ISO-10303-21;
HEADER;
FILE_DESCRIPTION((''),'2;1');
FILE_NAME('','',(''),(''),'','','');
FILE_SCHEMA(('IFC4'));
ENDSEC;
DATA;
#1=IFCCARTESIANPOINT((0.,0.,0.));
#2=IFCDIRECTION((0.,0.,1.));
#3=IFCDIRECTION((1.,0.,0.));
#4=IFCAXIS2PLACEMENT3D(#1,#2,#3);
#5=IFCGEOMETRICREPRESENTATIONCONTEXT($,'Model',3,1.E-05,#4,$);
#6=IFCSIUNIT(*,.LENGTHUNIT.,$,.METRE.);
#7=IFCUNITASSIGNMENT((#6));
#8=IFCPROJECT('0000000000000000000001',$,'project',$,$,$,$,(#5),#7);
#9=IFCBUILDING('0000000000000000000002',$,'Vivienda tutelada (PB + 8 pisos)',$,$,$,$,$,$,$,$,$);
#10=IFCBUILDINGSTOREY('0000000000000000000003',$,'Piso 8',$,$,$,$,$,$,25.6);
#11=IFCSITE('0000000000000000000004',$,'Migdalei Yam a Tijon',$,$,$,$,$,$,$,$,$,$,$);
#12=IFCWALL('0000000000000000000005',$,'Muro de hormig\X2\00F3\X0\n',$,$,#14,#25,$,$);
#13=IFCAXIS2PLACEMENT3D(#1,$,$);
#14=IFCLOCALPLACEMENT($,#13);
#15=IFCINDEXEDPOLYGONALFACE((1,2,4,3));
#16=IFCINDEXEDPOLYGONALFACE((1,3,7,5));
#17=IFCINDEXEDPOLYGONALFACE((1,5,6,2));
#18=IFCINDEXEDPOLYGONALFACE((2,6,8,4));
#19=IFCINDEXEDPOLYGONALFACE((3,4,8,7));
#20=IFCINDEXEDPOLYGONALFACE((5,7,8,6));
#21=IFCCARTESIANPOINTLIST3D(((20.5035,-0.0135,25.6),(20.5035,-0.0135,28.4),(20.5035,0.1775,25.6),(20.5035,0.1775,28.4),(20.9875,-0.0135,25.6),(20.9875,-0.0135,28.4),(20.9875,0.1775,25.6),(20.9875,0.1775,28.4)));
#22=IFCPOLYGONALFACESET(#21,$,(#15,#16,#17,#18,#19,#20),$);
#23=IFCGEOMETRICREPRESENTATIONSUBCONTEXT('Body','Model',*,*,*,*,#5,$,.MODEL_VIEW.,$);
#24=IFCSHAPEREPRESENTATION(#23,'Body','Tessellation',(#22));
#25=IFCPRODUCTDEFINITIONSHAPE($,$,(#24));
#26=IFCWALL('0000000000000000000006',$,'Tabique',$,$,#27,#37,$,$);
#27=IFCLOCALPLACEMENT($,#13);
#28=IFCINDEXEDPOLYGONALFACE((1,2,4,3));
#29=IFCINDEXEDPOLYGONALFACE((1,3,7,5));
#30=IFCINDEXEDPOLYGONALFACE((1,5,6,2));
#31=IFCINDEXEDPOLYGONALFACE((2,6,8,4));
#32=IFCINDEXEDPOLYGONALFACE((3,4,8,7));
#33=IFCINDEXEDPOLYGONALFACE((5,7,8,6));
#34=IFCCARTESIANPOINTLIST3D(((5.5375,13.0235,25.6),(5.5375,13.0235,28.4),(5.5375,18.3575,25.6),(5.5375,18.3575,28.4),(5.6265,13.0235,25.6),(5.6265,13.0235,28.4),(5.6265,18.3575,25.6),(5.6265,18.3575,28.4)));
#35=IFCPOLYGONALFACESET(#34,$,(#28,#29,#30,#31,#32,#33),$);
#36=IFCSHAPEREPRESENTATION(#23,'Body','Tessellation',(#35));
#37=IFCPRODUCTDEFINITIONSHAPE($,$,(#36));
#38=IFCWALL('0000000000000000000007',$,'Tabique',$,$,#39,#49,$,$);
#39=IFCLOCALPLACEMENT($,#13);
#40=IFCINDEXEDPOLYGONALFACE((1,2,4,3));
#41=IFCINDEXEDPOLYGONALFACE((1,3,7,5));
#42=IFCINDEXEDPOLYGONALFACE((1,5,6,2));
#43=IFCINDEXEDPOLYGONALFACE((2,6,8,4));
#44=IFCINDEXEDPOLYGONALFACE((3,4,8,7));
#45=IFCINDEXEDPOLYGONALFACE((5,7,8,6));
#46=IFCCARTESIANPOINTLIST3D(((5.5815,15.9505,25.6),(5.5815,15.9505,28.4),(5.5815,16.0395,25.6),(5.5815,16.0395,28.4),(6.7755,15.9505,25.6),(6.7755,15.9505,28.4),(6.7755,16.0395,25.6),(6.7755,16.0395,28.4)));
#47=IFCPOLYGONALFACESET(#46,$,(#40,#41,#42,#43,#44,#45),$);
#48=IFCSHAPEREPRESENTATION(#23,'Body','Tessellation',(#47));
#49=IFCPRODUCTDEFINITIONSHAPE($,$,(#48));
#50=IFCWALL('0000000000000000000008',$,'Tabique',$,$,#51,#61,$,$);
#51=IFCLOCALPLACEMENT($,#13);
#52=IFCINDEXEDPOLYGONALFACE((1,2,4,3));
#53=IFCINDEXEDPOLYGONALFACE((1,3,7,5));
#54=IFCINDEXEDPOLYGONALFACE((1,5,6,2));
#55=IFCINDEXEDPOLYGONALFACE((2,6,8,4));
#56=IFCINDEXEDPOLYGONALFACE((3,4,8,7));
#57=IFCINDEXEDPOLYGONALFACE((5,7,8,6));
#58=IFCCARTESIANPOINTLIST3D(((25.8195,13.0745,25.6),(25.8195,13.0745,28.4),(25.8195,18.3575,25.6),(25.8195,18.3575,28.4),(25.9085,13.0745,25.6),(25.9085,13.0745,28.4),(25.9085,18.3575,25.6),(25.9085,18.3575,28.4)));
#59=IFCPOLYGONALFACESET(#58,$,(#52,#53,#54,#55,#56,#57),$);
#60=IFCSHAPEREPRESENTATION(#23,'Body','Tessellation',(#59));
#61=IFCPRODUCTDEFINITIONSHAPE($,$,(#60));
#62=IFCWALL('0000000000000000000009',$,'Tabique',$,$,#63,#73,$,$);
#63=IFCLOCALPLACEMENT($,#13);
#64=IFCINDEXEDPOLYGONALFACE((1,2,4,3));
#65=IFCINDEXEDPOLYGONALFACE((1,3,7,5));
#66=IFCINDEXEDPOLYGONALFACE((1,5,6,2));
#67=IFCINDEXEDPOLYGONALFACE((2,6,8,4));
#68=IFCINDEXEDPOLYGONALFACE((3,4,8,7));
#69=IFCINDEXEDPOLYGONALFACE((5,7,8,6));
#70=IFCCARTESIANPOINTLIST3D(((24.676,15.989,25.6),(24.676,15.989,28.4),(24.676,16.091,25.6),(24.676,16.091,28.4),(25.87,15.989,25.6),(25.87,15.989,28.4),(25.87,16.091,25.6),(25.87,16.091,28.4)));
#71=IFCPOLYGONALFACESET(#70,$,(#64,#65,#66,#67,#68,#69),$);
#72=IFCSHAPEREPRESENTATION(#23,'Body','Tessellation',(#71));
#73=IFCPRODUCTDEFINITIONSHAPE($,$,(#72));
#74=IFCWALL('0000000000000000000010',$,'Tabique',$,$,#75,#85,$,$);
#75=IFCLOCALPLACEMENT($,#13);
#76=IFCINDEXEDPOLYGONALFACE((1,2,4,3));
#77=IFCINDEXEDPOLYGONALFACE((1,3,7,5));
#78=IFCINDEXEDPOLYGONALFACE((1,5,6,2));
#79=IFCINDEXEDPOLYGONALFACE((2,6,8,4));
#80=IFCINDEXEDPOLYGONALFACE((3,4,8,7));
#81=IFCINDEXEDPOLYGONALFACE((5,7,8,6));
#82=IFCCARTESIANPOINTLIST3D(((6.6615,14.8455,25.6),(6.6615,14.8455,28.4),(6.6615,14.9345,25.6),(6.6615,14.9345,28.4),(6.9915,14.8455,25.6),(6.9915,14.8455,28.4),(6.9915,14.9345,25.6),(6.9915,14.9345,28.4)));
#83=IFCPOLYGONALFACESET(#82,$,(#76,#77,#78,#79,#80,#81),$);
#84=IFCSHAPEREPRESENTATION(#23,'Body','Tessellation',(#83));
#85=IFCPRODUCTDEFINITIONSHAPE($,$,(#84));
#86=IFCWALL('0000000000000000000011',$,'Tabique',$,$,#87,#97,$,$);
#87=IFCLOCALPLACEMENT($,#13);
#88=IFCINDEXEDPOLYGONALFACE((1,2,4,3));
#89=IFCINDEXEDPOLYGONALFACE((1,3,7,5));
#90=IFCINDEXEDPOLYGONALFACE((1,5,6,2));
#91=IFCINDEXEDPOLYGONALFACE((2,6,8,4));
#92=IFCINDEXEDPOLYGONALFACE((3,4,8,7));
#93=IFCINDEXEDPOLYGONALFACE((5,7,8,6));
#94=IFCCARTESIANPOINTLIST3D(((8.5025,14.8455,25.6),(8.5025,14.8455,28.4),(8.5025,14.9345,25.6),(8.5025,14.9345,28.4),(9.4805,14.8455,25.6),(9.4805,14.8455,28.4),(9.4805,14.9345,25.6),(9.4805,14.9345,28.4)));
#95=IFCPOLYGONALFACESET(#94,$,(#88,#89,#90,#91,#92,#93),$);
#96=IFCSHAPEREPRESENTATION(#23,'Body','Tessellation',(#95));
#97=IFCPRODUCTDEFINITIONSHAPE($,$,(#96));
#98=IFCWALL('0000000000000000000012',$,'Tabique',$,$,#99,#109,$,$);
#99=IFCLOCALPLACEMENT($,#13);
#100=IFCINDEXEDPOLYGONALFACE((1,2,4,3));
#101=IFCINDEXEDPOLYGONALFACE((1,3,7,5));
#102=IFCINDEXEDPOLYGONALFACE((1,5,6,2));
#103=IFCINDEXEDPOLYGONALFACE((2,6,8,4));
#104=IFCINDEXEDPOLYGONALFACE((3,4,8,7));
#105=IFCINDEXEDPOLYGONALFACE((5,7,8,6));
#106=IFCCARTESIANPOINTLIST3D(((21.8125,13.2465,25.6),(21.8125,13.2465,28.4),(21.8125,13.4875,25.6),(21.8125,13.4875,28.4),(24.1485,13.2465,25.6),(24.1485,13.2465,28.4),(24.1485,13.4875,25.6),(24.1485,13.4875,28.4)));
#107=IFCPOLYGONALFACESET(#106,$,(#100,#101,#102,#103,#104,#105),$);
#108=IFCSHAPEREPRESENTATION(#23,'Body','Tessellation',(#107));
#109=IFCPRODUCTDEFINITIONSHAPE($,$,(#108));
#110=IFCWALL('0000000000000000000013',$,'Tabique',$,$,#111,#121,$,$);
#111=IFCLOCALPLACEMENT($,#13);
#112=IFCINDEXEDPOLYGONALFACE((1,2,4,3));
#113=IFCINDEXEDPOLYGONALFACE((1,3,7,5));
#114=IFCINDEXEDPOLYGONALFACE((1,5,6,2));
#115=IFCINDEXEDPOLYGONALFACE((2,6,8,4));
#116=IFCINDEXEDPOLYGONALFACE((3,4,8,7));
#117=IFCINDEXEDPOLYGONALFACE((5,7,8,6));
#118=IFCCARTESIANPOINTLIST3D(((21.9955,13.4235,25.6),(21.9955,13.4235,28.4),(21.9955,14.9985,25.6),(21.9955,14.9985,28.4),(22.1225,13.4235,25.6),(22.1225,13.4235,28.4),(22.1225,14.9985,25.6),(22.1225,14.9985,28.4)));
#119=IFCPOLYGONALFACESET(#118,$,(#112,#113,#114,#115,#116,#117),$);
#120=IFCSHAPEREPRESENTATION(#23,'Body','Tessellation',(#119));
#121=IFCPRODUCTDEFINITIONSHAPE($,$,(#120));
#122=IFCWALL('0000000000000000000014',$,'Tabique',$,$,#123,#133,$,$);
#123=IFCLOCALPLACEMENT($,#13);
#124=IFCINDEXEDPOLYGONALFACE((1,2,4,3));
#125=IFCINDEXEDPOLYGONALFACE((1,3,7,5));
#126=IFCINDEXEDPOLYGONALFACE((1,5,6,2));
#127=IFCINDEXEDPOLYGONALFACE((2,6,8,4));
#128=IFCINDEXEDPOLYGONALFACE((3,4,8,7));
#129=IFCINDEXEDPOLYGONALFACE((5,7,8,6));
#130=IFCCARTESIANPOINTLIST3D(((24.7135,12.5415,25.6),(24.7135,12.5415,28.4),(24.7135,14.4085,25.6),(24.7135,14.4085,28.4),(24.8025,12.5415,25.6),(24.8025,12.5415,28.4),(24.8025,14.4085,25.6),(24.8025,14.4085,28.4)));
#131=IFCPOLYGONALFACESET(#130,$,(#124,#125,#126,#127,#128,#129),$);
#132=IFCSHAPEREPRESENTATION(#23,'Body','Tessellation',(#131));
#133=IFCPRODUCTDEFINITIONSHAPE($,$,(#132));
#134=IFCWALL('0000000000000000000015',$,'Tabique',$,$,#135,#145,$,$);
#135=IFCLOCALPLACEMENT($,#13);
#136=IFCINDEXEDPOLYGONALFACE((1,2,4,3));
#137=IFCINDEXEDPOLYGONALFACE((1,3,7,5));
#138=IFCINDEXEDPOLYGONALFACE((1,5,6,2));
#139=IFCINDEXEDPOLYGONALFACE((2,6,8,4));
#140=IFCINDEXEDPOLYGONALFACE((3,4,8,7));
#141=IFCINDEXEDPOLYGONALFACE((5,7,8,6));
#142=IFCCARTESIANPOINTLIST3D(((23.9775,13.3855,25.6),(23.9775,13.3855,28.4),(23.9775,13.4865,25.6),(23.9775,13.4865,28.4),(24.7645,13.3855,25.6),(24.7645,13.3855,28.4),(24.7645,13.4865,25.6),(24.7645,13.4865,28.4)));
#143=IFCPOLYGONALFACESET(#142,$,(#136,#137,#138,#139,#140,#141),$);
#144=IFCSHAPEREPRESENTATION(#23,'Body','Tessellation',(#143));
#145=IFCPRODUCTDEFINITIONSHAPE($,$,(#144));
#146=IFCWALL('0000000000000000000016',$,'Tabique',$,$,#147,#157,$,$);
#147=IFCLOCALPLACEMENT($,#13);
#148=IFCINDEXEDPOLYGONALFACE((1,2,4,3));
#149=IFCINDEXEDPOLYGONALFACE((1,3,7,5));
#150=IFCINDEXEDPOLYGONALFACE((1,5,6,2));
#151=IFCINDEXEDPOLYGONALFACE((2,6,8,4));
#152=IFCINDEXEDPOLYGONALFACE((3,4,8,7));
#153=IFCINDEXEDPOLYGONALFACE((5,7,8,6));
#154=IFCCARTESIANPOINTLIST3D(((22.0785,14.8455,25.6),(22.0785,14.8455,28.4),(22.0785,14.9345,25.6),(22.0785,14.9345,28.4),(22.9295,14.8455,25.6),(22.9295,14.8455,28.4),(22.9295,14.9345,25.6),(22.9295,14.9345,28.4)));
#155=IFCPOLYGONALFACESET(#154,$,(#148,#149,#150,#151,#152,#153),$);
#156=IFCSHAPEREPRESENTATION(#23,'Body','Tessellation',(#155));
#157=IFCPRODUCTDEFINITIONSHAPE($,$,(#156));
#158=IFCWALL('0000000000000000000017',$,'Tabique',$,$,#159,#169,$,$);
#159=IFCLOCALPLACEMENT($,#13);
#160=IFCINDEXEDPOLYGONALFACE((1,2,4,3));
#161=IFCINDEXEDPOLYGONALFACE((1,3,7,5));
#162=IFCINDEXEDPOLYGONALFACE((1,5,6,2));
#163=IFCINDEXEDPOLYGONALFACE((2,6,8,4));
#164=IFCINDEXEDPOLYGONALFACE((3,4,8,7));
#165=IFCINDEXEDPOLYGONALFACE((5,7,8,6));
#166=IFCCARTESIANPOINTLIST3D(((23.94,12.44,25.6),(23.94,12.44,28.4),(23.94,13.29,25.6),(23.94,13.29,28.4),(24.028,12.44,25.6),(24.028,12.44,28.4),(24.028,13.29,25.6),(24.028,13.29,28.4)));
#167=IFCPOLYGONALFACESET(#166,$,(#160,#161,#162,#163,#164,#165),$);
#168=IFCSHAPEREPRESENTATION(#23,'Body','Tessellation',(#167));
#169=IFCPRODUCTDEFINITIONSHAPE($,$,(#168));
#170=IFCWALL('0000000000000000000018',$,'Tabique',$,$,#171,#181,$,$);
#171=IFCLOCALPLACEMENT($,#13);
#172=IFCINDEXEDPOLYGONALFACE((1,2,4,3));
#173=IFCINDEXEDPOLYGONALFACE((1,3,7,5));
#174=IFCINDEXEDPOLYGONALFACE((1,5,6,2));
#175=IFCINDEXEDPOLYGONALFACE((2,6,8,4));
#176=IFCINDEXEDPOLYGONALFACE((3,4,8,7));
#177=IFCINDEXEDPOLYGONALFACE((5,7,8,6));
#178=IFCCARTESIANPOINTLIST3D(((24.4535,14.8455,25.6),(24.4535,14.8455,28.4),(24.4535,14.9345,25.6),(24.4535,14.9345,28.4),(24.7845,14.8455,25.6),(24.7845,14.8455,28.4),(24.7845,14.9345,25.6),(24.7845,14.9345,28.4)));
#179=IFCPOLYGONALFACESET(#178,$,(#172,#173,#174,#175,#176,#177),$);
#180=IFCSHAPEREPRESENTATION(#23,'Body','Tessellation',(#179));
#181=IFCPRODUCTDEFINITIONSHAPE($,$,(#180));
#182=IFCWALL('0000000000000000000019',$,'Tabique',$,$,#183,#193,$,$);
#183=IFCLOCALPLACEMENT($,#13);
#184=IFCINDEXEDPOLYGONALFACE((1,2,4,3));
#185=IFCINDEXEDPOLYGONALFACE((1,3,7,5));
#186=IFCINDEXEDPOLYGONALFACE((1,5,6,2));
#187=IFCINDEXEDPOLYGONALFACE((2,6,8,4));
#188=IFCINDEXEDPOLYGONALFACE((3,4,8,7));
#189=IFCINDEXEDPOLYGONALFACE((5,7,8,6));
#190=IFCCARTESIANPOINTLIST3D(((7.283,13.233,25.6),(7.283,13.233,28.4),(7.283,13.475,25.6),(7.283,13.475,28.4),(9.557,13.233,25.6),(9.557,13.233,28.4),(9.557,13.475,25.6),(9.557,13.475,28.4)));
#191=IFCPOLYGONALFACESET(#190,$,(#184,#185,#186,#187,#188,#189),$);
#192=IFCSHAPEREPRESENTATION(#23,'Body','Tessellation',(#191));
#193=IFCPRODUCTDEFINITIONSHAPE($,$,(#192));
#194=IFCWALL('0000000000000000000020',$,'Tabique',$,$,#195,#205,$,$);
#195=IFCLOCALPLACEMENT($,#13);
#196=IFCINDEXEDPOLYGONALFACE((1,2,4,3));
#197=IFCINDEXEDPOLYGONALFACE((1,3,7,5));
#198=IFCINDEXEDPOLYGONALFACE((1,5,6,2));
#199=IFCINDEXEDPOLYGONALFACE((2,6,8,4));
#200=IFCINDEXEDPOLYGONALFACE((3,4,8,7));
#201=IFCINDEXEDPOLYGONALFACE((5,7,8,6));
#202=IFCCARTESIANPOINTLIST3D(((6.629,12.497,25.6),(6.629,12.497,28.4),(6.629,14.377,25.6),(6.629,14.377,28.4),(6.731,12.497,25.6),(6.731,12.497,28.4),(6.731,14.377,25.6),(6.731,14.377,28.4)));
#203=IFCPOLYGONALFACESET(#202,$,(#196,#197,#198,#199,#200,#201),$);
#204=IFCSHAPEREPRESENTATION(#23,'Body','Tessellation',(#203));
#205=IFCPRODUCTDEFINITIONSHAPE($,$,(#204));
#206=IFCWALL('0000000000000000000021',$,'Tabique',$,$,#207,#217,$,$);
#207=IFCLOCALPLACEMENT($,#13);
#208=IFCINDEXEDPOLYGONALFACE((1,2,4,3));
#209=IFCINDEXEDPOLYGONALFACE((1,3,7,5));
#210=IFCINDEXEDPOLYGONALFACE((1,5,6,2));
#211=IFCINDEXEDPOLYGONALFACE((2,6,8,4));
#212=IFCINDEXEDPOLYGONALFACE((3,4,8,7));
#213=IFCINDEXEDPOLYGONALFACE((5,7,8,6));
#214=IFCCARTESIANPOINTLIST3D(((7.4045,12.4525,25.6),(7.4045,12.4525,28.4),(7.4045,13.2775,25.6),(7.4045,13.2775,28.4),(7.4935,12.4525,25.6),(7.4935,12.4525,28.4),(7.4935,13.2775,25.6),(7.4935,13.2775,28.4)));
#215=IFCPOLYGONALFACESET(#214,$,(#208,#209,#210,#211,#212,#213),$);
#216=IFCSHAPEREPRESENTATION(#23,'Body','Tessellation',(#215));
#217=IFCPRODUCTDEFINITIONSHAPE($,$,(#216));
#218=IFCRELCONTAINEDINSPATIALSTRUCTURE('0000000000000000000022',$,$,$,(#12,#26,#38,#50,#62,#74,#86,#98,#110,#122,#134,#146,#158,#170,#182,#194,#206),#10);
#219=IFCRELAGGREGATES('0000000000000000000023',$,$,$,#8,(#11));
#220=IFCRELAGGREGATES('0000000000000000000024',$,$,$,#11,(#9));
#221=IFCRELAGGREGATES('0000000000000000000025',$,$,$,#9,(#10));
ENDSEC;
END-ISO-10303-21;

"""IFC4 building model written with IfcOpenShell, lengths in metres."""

from ifc_helpers import new_model, si_unit, frame, origin_with_axes, context, subcontext, project, spatial, line, indexed_curve, outline, extrude, element, save


model = new_model("IFC4")

# Units and contexts
model_context = context("Model", 3, precision=1e-05, world=origin_with_axes())
body_context = subcontext(model_context, "Body", "Model", "MODEL_VIEW")
ifc_project = project(units=[si_unit("LENGTHUNIT", "METRE")], contexts=[model_context])

# Site, building, storey
site = spatial("IfcSite", under=ifc_project, Name="Migdalei Yam a Tijon")
building = spatial("IfcBuilding", under=site, Name="Vivienda tutelada (PB + 8 pisos)")
storey = spatial("IfcBuildingStorey", under=building, Name="Piso 8", Elevation=25.6)

# Walls
element("IfcWall", 1, inside=storey, Name="Muro de hormigón", context=body_context, shape_type="SweptSolid", body=[
    extrude(outline(indexed_curve([(0.0, 0.0), (0.484, 0.0), (0.484, 0.191), (0.0, 0.191)], segments=[line(1, 2, 3, 4, 1)])), frame((20.5035, -0.0135, 25.6), z_axis=(0.0, 0.0, 1.0), x_axis=(1.0, 0.0, 0.0)), (0.0, 0.0, 1.0), 2.8),
])
element("IfcWall", 2, inside=storey, Name="Tabique", context=body_context, shape_type="SweptSolid", body=[
    extrude(outline(indexed_curve([(0.0, 0.0), (0.089, 0.0), (0.089, 5.334), (0.0, 5.334)], segments=[line(1, 2, 3, 4, 1)])), frame((5.5375, 13.0235, 25.6), z_axis=(0.0, 0.0, 1.0), x_axis=(1.0, 0.0, 0.0)), (0.0, 0.0, 1.0), 2.8),
])
element("IfcWall", 3, inside=storey, Name="Tabique", context=body_context, shape_type="SweptSolid", body=[
    extrude(outline(indexed_curve([(0.0, 0.0), (1.194, 0.0), (1.194, 0.089), (0.0, 0.089)], segments=[line(1, 2, 3, 4, 1)])), frame((5.5815, 15.9505, 25.6), z_axis=(0.0, 0.0, 1.0), x_axis=(1.0, 0.0, 0.0)), (0.0, 0.0, 1.0), 2.8),
])
element("IfcWall", 4, inside=storey, Name="Tabique", context=body_context, shape_type="SweptSolid", body=[
    extrude(outline(indexed_curve([(0.0, 0.0), (0.089, 0.0), (0.089, 5.283), (0.0, 5.283)], segments=[line(1, 2, 3, 4, 1)])), frame((25.8195, 13.0745, 25.6), z_axis=(0.0, 0.0, 1.0), x_axis=(1.0, 0.0, 0.0)), (0.0, 0.0, 1.0), 2.8),
])
element("IfcWall", 5, inside=storey, Name="Tabique", context=body_context, shape_type="SweptSolid", body=[
    extrude(outline(indexed_curve([(0.0, 0.0), (1.194, 0.0), (1.194, 0.102), (0.0, 0.102)], segments=[line(1, 2, 3, 4, 1)])), frame((24.676, 15.989, 25.6), z_axis=(0.0, 0.0, 1.0), x_axis=(1.0, 0.0, 0.0)), (0.0, 0.0, 1.0), 2.8),
])
element("IfcWall", 6, inside=storey, Name="Tabique", context=body_context, shape_type="SweptSolid", body=[
    extrude(outline(indexed_curve([(0.0, 0.0), (0.33, 0.0), (0.33, 0.089), (0.0, 0.089)], segments=[line(1, 2, 3, 4, 1)])), frame((6.6615, 14.8455, 25.6), z_axis=(0.0, 0.0, 1.0), x_axis=(1.0, 0.0, 0.0)), (0.0, 0.0, 1.0), 2.8),
])
element("IfcWall", 7, inside=storey, Name="Tabique", context=body_context, shape_type="SweptSolid", body=[
    extrude(outline(indexed_curve([(0.0, 0.0), (0.978, 0.0), (0.978, 0.089), (0.0, 0.089)], segments=[line(1, 2, 3, 4, 1)])), frame((8.5025, 14.8455, 25.6), z_axis=(0.0, 0.0, 1.0), x_axis=(1.0, 0.0, 0.0)), (0.0, 0.0, 1.0), 2.8),
])
element("IfcWall", 8, inside=storey, Name="Tabique", context=body_context, shape_type="SweptSolid", body=[
    extrude(outline(indexed_curve([(0.0, 0.0), (2.336, 0.0), (2.336, 0.241), (0.0, 0.241)], segments=[line(1, 2, 3, 4, 1)])), frame((21.8125, 13.2465, 25.6), z_axis=(0.0, 0.0, 1.0), x_axis=(1.0, 0.0, 0.0)), (0.0, 0.0, 1.0), 2.8),
])
element("IfcWall", 9, inside=storey, Name="Tabique", context=body_context, shape_type="SweptSolid", body=[
    extrude(outline(indexed_curve([(0.0, 0.0), (0.127, 0.0), (0.127, 1.575), (0.0, 1.575)], segments=[line(1, 2, 3, 4, 1)])), frame((21.9955, 13.4235, 25.6), z_axis=(0.0, 0.0, 1.0), x_axis=(1.0, 0.0, 0.0)), (0.0, 0.0, 1.0), 2.8),
])
element("IfcWall", 10, inside=storey, Name="Tabique", context=body_context, shape_type="SweptSolid", body=[
    extrude(outline(indexed_curve([(0.0, 0.0), (0.089, 0.0), (0.089, 1.867), (0.0, 1.867)], segments=[line(1, 2, 3, 4, 1)])), frame((24.7135, 12.5415, 25.6), z_axis=(0.0, 0.0, 1.0), x_axis=(1.0, 0.0, 0.0)), (0.0, 0.0, 1.0), 2.8),
])
element("IfcWall", 11, inside=storey, Name="Tabique", context=body_context, shape_type="SweptSolid", body=[
    extrude(outline(indexed_curve([(0.0, 0.0), (0.787, 0.0), (0.787, 0.101), (0.0, 0.101)], segments=[line(1, 2, 3, 4, 1)])), frame((23.9775, 13.3855, 25.6), z_axis=(0.0, 0.0, 1.0), x_axis=(1.0, 0.0, 0.0)), (0.0, 0.0, 1.0), 2.8),
])
element("IfcWall", 12, inside=storey, Name="Tabique", context=body_context, shape_type="SweptSolid", body=[
    extrude(outline(indexed_curve([(0.0, 0.0), (0.851, 0.0), (0.851, 0.089), (0.0, 0.089)], segments=[line(1, 2, 3, 4, 1)])), frame((22.0785, 14.8455, 25.6), z_axis=(0.0, 0.0, 1.0), x_axis=(1.0, 0.0, 0.0)), (0.0, 0.0, 1.0), 2.8),
])
element("IfcWall", 13, inside=storey, Name="Tabique", context=body_context, shape_type="SweptSolid", body=[
    extrude(outline(indexed_curve([(0.0, 0.0), (0.088, 0.0), (0.088, 0.85), (0.0, 0.85)], segments=[line(1, 2, 3, 4, 1)])), frame((23.94, 12.44, 25.6), z_axis=(0.0, 0.0, 1.0), x_axis=(1.0, 0.0, 0.0)), (0.0, 0.0, 1.0), 2.8),
])
element("IfcWall", 14, inside=storey, Name="Tabique", context=body_context, shape_type="SweptSolid", body=[
    extrude(outline(indexed_curve([(0.0, 0.0), (0.331, 0.0), (0.331, 0.089), (0.0, 0.089)], segments=[line(1, 2, 3, 4, 1)])), frame((24.4535, 14.8455, 25.6), z_axis=(0.0, 0.0, 1.0), x_axis=(1.0, 0.0, 0.0)), (0.0, 0.0, 1.0), 2.8),
])
element("IfcWall", 15, inside=storey, Name="Tabique", context=body_context, shape_type="SweptSolid", body=[
    extrude(outline(indexed_curve([(0.0, 0.0), (2.274, 0.0), (2.274, 0.242), (0.0, 0.242)], segments=[line(1, 2, 3, 4, 1)])), frame((7.283, 13.233, 25.6), z_axis=(0.0, 0.0, 1.0), x_axis=(1.0, 0.0, 0.0)), (0.0, 0.0, 1.0), 2.8),
])
element("IfcWall", 16, inside=storey, Name="Tabique", context=body_context, shape_type="SweptSolid", body=[
    extrude(outline(indexed_curve([(0.0, 0.0), (0.102, 0.0), (0.102, 1.88), (0.0, 1.88)], segments=[line(1, 2, 3, 4, 1)])), frame((6.629, 12.497, 25.6), z_axis=(0.0, 0.0, 1.0), x_axis=(1.0, 0.0, 0.0)), (0.0, 0.0, 1.0), 2.8),
])
element("IfcWall", 17, inside=storey, Name="Tabique", context=body_context, shape_type="SweptSolid", body=[
    extrude(outline(indexed_curve([(0.0, 0.0), (0.089, 0.0), (0.089, 0.825), (0.0, 0.825)], segments=[line(1, 2, 3, 4, 1)])), frame((7.4045, 12.4525, 25.6), z_axis=(0.0, 0.0, 1.0), x_axis=(1.0, 0.0, 0.0)), (0.0, 0.0, 1.0), 2.8),
])

save(model, "model.ifc")
